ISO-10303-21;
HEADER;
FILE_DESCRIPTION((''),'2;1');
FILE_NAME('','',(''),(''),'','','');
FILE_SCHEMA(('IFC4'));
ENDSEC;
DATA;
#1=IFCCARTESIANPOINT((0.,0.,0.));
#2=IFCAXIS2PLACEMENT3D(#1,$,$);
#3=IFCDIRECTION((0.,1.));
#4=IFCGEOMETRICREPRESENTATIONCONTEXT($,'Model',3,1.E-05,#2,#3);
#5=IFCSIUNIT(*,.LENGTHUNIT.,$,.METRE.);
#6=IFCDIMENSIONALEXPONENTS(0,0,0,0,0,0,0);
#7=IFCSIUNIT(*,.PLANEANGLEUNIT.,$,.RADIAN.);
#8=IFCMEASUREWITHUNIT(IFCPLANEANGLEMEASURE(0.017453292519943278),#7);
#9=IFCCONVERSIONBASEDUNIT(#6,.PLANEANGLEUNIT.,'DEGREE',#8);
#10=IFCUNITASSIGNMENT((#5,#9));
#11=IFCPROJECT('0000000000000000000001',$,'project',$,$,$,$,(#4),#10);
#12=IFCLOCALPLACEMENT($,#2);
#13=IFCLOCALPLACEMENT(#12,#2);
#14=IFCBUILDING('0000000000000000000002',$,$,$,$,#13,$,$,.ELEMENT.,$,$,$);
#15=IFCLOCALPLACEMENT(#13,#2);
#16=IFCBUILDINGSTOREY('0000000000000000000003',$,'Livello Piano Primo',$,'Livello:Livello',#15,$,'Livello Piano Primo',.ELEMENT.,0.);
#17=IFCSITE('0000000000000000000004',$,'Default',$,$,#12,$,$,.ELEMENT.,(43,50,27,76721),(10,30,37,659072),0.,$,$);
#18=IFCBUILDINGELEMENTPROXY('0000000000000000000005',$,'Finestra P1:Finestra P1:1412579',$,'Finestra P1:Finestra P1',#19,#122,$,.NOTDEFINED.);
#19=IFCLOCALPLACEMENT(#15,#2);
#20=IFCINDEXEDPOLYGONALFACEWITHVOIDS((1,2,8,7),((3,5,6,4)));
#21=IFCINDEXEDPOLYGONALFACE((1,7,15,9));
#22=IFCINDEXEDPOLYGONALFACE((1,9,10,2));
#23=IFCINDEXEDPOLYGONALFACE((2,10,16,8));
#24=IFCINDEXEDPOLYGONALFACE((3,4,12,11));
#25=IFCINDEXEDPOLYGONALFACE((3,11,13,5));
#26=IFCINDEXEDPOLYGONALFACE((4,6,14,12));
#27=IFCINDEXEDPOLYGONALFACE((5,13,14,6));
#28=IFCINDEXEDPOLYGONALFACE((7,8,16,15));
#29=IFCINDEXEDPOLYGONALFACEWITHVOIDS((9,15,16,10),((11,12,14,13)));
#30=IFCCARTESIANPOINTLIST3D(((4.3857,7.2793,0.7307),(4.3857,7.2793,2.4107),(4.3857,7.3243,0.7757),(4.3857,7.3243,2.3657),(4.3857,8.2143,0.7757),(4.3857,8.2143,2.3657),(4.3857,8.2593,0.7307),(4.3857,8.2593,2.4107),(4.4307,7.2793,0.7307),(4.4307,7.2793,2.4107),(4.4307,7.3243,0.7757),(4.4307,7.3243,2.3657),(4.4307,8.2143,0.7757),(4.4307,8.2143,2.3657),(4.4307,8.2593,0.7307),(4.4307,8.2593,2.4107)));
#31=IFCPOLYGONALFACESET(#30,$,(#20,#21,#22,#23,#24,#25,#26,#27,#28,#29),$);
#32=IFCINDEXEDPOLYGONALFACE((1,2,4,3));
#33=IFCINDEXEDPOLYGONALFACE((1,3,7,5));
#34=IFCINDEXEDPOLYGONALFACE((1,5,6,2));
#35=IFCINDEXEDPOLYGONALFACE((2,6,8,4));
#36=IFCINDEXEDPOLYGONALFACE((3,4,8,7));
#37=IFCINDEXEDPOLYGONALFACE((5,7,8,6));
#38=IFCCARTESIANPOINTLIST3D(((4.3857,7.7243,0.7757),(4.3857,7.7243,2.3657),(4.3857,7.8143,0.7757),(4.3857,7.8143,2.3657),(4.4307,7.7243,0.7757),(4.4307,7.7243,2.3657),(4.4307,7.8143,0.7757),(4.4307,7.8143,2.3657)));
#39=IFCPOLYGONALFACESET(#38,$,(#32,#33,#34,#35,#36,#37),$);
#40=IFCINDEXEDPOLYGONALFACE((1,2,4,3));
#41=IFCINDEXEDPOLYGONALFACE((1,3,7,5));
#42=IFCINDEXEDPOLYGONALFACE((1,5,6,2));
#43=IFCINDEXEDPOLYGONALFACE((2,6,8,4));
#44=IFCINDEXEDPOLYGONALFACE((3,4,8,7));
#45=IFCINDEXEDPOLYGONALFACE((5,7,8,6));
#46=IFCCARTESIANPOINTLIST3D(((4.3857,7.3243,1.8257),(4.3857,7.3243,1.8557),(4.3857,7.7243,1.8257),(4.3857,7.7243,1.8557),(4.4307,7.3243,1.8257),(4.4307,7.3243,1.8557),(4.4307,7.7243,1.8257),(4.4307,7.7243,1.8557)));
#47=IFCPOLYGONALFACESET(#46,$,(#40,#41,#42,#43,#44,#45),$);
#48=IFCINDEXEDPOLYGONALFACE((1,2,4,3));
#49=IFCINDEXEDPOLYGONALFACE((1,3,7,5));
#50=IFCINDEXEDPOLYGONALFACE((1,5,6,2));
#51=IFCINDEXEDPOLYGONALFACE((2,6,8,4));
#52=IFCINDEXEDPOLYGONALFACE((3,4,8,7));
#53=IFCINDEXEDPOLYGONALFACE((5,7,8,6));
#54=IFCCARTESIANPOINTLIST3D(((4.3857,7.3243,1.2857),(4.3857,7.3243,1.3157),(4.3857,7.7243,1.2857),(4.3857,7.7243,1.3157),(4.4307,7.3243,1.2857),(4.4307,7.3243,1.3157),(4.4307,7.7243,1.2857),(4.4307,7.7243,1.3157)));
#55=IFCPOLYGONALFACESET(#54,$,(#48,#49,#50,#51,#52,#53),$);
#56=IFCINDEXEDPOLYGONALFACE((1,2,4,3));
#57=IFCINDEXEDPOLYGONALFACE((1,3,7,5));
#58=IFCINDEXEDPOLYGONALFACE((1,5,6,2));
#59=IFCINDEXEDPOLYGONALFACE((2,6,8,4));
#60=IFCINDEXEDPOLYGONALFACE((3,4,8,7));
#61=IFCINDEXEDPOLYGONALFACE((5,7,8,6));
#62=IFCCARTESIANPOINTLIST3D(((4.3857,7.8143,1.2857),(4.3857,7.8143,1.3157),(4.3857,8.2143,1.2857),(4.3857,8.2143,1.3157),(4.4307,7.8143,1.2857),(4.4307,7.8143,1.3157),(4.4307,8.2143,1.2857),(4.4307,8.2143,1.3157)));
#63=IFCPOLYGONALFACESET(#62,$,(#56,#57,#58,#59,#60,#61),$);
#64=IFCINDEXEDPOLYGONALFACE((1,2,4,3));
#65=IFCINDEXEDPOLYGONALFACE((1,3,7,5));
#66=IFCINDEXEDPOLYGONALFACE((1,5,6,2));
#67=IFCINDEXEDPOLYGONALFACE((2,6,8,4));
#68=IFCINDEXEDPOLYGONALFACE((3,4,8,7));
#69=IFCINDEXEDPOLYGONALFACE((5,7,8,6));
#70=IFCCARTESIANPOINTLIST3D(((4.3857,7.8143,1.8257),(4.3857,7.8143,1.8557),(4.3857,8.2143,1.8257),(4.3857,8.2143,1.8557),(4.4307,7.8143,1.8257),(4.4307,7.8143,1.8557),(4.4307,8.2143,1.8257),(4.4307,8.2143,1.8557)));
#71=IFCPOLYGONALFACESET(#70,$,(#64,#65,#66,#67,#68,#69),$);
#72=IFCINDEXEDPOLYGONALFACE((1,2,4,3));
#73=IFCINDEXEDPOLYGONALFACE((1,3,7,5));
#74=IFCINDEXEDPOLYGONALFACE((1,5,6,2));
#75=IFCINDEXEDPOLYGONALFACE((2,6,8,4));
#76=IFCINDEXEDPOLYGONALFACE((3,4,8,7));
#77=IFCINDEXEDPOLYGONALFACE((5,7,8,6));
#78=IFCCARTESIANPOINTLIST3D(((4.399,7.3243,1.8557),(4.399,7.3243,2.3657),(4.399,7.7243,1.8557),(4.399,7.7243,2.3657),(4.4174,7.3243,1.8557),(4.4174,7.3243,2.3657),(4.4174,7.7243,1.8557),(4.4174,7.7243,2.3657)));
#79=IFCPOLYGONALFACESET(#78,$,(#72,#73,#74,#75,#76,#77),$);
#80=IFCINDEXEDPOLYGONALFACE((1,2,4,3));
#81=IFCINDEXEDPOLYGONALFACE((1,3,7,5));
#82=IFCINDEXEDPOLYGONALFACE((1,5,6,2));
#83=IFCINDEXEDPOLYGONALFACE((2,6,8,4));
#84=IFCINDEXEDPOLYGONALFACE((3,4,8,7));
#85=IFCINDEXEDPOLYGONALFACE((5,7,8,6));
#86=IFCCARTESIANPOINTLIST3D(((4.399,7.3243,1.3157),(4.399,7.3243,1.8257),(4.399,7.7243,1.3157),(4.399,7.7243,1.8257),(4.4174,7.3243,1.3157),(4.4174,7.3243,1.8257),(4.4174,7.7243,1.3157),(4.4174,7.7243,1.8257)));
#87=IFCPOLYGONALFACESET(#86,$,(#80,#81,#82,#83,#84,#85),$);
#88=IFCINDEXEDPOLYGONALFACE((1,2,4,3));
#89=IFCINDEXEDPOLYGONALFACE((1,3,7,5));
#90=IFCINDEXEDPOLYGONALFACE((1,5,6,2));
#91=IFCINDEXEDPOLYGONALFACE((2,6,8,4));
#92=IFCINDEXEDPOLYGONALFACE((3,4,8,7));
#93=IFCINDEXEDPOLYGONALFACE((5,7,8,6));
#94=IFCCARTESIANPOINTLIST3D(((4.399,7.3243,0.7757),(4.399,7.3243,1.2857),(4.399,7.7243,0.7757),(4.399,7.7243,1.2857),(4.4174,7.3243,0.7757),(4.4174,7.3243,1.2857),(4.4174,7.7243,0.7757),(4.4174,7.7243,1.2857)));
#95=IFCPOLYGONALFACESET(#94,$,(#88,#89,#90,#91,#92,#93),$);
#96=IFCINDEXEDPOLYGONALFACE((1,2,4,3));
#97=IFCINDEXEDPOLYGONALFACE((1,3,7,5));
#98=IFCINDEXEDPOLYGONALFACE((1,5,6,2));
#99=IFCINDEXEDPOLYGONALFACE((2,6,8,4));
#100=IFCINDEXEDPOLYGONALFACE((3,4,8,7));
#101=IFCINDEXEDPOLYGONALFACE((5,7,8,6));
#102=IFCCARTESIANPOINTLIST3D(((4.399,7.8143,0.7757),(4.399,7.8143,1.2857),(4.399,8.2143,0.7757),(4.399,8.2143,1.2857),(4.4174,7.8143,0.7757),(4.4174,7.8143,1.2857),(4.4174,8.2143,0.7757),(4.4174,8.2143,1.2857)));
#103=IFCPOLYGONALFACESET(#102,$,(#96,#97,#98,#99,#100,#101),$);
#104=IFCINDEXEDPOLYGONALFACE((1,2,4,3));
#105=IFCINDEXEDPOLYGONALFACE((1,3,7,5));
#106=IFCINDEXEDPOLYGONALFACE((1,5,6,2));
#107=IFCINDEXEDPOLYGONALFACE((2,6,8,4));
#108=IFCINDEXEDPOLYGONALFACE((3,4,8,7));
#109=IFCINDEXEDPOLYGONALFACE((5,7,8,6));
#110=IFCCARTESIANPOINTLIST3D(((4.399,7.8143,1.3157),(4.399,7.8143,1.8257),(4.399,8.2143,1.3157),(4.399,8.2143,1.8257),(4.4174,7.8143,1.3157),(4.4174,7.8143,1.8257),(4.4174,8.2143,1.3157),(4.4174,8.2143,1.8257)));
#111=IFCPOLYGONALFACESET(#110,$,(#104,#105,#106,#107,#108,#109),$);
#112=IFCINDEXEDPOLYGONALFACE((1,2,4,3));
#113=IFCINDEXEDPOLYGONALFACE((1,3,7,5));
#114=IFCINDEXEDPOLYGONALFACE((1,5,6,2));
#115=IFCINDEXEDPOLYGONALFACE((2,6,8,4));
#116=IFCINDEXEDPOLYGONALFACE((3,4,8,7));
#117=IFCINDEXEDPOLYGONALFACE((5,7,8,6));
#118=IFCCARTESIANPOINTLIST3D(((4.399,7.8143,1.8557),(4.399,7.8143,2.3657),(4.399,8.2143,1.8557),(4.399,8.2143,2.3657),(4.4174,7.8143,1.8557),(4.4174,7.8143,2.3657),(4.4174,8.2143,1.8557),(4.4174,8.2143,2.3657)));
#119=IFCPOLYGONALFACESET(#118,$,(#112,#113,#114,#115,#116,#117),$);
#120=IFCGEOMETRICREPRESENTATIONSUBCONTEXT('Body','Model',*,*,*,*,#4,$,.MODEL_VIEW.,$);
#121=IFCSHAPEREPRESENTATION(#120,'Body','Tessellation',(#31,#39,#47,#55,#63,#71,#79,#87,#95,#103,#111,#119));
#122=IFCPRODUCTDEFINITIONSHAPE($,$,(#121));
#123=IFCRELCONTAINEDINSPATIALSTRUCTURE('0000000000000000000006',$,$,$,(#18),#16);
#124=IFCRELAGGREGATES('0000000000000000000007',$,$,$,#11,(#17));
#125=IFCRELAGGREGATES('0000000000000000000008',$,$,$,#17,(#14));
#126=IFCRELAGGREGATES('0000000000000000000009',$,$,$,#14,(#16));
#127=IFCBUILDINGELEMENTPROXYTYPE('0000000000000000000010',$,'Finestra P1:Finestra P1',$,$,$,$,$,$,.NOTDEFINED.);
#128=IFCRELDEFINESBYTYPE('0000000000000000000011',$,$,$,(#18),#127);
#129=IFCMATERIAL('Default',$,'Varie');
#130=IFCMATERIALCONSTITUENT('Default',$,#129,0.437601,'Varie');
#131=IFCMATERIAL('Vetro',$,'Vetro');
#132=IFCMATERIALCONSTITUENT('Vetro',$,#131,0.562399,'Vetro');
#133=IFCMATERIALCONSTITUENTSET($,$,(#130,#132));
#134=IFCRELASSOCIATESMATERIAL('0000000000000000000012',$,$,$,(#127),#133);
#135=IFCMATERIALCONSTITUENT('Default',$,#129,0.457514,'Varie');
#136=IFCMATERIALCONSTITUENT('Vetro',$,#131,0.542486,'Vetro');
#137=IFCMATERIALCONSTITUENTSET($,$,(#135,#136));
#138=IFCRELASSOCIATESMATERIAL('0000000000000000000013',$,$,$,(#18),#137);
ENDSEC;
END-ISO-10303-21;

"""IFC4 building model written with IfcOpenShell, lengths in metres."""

from ifc_helpers import new_model, entity, si_unit, converted_unit, direction, frame, origin, place, context, subcontext, project, spatial, indexed_curve, outline, extrude, source, transform, mapped, material, constituent, constituent_set, type_object, type_shapes, element, save


model = new_model("IFC4")

# Units and contexts
model_context = context("Model", 3, precision=1e-05, world=origin(), true_north=direction((0.0, 1.0)))
body_context = subcontext(model_context, "Body", "Model", "MODEL_VIEW")
ifc_project = project(units=[si_unit("LENGTHUNIT", "METRE"), converted_unit("PLANEANGLEUNIT", "DEGREE", entity("IfcPlaneAngleMeasure", 0.017453292519943278), si_unit("PLANEANGLEUNIT", "RADIAN"), dimensions=[0, 0, 0, 0, 0, 0, 0])], contexts=[model_context])

# Site, building, storey
site_placement = place(None, origin())
site = spatial("IfcSite", under=ifc_project, at=site_placement, Name="Default", CompositionType="ELEMENT", RefLatitude=(43, 50, 27, 76721), RefLongitude=(10, 30, 37, 659072), RefElevation=0.0)
building_placement = place(site_placement, origin())
building = spatial("IfcBuilding", under=site, at=building_placement, CompositionType="ELEMENT")
storey_placement = place(building_placement, origin())
storey = spatial("IfcBuildingStorey", under=building, at=storey_placement, Name="Livello Piano Primo", ObjectType="Livello:Livello", LongName="Livello Piano Primo", CompositionType="ELEMENT", Elevation=0.0)

# Building element proxy
ifc_material_1 = material(Name="Default", Category="Varie")
ifc_material_2 = material(Name="Vetro", Category="Vetro")
ifc_constituent_1 = constituent(ifc_material_1, Name="Default", Category="Varie", fraction=0.457514)
ifc_constituent_2 = constituent(ifc_material_2, Name="Vetro", Category="Vetro", fraction=0.542486)
ifc_constituent_set_1 = constituent_set(constituents=[ifc_constituent_1, ifc_constituent_2])
ifc_constituent_3 = constituent(ifc_material_1, Name="Default", Category="Varie", fraction=0.437601)
ifc_constituent_4 = constituent(ifc_material_2, Name="Vetro", Category="Vetro", fraction=0.562399)
ifc_constituent_set_2 = constituent_set(constituents=[ifc_constituent_3, ifc_constituent_4])
building_element_proxy_type_1 = type_object("IfcBuildingElementProxyType", Name="Finestra P1:Finestra P1", PredefinedType="NOTDEFINED", material=ifc_constituent_set_2)
shared_shape_1 = source(origin(), body_context, "Body", "SweptSolid", [
    extrude(outline(indexed_curve([(-0.84, -0.49), (0.84, -0.49), (0.84, 0.49), (-0.84, 0.49), (-0.84, -0.49)], self_intersect=False), holes=[indexed_curve([(0.795, -0.445), (-0.795, -0.445), (-0.795, 0.445), (0.795, 0.445), (0.795, -0.445)], self_intersect=False)]), frame((0.0, -0.0225, 0.84), z_axis=(0.0, 1.0, 0.0), x_axis=(0.0, 0.0, -1.0)), (0.0, 0.0, 1.0), 0.045),
    extrude(outline(indexed_curve([(-0.045, -0.0225), (0.045, -0.0225), (0.045, 0.0225), (-0.045, 0.0225), (-0.045, -0.0225)], self_intersect=False)), frame((0.0, 0.0, 0.045), z_axis=(0.0, 0.0, 1.0), x_axis=(-1.0, 0.0, 0.0)), (0.0, 0.0, 1.0), 1.59),
    extrude(outline(indexed_curve([(-0.2, -0.0225), (0.2, -0.0225), (0.2, 0.0225), (-0.2, 0.0225), (-0.2, -0.0225)], self_intersect=False)), frame((0.245, 0.0, 1.095)), (0.0, 0.0, 1.0), 0.03),
    extrude(outline(indexed_curve([(-0.2, -0.0225), (0.2, -0.0225), (0.2, 0.0225), (-0.2, 0.0225), (-0.2, -0.0225)], self_intersect=False)), frame((0.245, 0.0, 0.555)), (0.0, 0.0, 1.0), 0.03),
    extrude(outline(indexed_curve([(-0.2, -0.0225), (0.2, -0.0225), (0.2, 0.0225), (-0.2, 0.0225), (-0.2, -0.0225)], self_intersect=False)), frame((-0.245, 0.0, 0.555)), (0.0, 0.0, 1.0), 0.03),
    extrude(outline(indexed_curve([(-0.2, -0.0225), (0.2, -0.0225), (0.2, 0.0225), (-0.2, 0.0225), (-0.2, -0.0225)], self_intersect=False)), frame((-0.245, 0.0, 1.095)), (0.0, 0.0, 1.0), 0.03),
    extrude(outline(indexed_curve([(-0.2, -0.0092), (0.2, -0.0092), (0.2, 0.0092), (-0.2, 0.0092), (-0.2, -0.0092)], self_intersect=False)), frame((0.245, 0.0, 1.125), z_axis=(0.0, 0.0, 1.0), x_axis=(-1.0, 0.0, 0.0)), (0.0, 0.0, 1.0), 0.51),
    extrude(outline(indexed_curve([(-0.2, -0.0092), (0.2, -0.0092), (0.2, 0.0092), (-0.2, 0.0092), (-0.2, -0.0092)], self_intersect=False)), frame((0.245, 0.0, 0.585), z_axis=(0.0, 0.0, 1.0), x_axis=(-1.0, 0.0, 0.0)), (0.0, 0.0, 1.0), 0.51),
    extrude(outline(indexed_curve([(-0.2, -0.0092), (0.2, -0.0092), (0.2, 0.0092), (-0.2, 0.0092), (-0.2, -0.0092)], self_intersect=False)), frame((0.245, 0.0, 0.045), z_axis=(0.0, 0.0, 1.0), x_axis=(-1.0, 0.0, 0.0)), (0.0, 0.0, 1.0), 0.51),
    extrude(outline(indexed_curve([(-0.2, -0.0092), (0.2, -0.0092), (0.2, 0.0092), (-0.2, 0.0092), (-0.2, -0.0092)], self_intersect=False)), frame((-0.245, 0.0, 0.045), z_axis=(0.0, 0.0, 1.0), x_axis=(-1.0, 0.0, 0.0)), (0.0, 0.0, 1.0), 0.51),
    extrude(outline(indexed_curve([(-0.2, -0.0092), (0.2, -0.0092), (0.2, 0.0092), (-0.2, 0.0092), (-0.2, -0.0092)], self_intersect=False)), frame((-0.245, 0.0, 0.585), z_axis=(0.0, 0.0, 1.0), x_axis=(-1.0, 0.0, 0.0)), (0.0, 0.0, 1.0), 0.51),
    extrude(outline(indexed_curve([(-0.2, -0.0092), (0.2, -0.0092), (0.2, 0.0092), (-0.2, 0.0092), (-0.2, -0.0092)], self_intersect=False)), frame((-0.245, 0.0, 1.125), z_axis=(0.0, 0.0, 1.0), x_axis=(-1.0, 0.0, 0.0)), (0.0, 0.0, 1.0), 0.51),
])
type_shapes(building_element_proxy_type_1, [shared_shape_1])
proxy_1_placement = place(storey_placement, frame((4.4082, 7.7693, 0.7307), z_axis=(0.0, 0.0, 1.0), x_axis=(0.0, -1.0, 0.0)))
element("IfcBuildingElementProxy", 1, at=proxy_1_placement, inside=storey, type_object=building_element_proxy_type_1, material=ifc_constituent_set_1, Name="Finestra P1:Finestra P1:1412579", ObjectType="Finestra P1:Finestra P1", PredefinedType="NOTDEFINED", context=body_context, shape_type="MappedRepresentation", body=[
    mapped(shared_shape_1, transform((0.0, 0.0, 0.0), scale=1.0)),
])

save(model, "model.ifc")
